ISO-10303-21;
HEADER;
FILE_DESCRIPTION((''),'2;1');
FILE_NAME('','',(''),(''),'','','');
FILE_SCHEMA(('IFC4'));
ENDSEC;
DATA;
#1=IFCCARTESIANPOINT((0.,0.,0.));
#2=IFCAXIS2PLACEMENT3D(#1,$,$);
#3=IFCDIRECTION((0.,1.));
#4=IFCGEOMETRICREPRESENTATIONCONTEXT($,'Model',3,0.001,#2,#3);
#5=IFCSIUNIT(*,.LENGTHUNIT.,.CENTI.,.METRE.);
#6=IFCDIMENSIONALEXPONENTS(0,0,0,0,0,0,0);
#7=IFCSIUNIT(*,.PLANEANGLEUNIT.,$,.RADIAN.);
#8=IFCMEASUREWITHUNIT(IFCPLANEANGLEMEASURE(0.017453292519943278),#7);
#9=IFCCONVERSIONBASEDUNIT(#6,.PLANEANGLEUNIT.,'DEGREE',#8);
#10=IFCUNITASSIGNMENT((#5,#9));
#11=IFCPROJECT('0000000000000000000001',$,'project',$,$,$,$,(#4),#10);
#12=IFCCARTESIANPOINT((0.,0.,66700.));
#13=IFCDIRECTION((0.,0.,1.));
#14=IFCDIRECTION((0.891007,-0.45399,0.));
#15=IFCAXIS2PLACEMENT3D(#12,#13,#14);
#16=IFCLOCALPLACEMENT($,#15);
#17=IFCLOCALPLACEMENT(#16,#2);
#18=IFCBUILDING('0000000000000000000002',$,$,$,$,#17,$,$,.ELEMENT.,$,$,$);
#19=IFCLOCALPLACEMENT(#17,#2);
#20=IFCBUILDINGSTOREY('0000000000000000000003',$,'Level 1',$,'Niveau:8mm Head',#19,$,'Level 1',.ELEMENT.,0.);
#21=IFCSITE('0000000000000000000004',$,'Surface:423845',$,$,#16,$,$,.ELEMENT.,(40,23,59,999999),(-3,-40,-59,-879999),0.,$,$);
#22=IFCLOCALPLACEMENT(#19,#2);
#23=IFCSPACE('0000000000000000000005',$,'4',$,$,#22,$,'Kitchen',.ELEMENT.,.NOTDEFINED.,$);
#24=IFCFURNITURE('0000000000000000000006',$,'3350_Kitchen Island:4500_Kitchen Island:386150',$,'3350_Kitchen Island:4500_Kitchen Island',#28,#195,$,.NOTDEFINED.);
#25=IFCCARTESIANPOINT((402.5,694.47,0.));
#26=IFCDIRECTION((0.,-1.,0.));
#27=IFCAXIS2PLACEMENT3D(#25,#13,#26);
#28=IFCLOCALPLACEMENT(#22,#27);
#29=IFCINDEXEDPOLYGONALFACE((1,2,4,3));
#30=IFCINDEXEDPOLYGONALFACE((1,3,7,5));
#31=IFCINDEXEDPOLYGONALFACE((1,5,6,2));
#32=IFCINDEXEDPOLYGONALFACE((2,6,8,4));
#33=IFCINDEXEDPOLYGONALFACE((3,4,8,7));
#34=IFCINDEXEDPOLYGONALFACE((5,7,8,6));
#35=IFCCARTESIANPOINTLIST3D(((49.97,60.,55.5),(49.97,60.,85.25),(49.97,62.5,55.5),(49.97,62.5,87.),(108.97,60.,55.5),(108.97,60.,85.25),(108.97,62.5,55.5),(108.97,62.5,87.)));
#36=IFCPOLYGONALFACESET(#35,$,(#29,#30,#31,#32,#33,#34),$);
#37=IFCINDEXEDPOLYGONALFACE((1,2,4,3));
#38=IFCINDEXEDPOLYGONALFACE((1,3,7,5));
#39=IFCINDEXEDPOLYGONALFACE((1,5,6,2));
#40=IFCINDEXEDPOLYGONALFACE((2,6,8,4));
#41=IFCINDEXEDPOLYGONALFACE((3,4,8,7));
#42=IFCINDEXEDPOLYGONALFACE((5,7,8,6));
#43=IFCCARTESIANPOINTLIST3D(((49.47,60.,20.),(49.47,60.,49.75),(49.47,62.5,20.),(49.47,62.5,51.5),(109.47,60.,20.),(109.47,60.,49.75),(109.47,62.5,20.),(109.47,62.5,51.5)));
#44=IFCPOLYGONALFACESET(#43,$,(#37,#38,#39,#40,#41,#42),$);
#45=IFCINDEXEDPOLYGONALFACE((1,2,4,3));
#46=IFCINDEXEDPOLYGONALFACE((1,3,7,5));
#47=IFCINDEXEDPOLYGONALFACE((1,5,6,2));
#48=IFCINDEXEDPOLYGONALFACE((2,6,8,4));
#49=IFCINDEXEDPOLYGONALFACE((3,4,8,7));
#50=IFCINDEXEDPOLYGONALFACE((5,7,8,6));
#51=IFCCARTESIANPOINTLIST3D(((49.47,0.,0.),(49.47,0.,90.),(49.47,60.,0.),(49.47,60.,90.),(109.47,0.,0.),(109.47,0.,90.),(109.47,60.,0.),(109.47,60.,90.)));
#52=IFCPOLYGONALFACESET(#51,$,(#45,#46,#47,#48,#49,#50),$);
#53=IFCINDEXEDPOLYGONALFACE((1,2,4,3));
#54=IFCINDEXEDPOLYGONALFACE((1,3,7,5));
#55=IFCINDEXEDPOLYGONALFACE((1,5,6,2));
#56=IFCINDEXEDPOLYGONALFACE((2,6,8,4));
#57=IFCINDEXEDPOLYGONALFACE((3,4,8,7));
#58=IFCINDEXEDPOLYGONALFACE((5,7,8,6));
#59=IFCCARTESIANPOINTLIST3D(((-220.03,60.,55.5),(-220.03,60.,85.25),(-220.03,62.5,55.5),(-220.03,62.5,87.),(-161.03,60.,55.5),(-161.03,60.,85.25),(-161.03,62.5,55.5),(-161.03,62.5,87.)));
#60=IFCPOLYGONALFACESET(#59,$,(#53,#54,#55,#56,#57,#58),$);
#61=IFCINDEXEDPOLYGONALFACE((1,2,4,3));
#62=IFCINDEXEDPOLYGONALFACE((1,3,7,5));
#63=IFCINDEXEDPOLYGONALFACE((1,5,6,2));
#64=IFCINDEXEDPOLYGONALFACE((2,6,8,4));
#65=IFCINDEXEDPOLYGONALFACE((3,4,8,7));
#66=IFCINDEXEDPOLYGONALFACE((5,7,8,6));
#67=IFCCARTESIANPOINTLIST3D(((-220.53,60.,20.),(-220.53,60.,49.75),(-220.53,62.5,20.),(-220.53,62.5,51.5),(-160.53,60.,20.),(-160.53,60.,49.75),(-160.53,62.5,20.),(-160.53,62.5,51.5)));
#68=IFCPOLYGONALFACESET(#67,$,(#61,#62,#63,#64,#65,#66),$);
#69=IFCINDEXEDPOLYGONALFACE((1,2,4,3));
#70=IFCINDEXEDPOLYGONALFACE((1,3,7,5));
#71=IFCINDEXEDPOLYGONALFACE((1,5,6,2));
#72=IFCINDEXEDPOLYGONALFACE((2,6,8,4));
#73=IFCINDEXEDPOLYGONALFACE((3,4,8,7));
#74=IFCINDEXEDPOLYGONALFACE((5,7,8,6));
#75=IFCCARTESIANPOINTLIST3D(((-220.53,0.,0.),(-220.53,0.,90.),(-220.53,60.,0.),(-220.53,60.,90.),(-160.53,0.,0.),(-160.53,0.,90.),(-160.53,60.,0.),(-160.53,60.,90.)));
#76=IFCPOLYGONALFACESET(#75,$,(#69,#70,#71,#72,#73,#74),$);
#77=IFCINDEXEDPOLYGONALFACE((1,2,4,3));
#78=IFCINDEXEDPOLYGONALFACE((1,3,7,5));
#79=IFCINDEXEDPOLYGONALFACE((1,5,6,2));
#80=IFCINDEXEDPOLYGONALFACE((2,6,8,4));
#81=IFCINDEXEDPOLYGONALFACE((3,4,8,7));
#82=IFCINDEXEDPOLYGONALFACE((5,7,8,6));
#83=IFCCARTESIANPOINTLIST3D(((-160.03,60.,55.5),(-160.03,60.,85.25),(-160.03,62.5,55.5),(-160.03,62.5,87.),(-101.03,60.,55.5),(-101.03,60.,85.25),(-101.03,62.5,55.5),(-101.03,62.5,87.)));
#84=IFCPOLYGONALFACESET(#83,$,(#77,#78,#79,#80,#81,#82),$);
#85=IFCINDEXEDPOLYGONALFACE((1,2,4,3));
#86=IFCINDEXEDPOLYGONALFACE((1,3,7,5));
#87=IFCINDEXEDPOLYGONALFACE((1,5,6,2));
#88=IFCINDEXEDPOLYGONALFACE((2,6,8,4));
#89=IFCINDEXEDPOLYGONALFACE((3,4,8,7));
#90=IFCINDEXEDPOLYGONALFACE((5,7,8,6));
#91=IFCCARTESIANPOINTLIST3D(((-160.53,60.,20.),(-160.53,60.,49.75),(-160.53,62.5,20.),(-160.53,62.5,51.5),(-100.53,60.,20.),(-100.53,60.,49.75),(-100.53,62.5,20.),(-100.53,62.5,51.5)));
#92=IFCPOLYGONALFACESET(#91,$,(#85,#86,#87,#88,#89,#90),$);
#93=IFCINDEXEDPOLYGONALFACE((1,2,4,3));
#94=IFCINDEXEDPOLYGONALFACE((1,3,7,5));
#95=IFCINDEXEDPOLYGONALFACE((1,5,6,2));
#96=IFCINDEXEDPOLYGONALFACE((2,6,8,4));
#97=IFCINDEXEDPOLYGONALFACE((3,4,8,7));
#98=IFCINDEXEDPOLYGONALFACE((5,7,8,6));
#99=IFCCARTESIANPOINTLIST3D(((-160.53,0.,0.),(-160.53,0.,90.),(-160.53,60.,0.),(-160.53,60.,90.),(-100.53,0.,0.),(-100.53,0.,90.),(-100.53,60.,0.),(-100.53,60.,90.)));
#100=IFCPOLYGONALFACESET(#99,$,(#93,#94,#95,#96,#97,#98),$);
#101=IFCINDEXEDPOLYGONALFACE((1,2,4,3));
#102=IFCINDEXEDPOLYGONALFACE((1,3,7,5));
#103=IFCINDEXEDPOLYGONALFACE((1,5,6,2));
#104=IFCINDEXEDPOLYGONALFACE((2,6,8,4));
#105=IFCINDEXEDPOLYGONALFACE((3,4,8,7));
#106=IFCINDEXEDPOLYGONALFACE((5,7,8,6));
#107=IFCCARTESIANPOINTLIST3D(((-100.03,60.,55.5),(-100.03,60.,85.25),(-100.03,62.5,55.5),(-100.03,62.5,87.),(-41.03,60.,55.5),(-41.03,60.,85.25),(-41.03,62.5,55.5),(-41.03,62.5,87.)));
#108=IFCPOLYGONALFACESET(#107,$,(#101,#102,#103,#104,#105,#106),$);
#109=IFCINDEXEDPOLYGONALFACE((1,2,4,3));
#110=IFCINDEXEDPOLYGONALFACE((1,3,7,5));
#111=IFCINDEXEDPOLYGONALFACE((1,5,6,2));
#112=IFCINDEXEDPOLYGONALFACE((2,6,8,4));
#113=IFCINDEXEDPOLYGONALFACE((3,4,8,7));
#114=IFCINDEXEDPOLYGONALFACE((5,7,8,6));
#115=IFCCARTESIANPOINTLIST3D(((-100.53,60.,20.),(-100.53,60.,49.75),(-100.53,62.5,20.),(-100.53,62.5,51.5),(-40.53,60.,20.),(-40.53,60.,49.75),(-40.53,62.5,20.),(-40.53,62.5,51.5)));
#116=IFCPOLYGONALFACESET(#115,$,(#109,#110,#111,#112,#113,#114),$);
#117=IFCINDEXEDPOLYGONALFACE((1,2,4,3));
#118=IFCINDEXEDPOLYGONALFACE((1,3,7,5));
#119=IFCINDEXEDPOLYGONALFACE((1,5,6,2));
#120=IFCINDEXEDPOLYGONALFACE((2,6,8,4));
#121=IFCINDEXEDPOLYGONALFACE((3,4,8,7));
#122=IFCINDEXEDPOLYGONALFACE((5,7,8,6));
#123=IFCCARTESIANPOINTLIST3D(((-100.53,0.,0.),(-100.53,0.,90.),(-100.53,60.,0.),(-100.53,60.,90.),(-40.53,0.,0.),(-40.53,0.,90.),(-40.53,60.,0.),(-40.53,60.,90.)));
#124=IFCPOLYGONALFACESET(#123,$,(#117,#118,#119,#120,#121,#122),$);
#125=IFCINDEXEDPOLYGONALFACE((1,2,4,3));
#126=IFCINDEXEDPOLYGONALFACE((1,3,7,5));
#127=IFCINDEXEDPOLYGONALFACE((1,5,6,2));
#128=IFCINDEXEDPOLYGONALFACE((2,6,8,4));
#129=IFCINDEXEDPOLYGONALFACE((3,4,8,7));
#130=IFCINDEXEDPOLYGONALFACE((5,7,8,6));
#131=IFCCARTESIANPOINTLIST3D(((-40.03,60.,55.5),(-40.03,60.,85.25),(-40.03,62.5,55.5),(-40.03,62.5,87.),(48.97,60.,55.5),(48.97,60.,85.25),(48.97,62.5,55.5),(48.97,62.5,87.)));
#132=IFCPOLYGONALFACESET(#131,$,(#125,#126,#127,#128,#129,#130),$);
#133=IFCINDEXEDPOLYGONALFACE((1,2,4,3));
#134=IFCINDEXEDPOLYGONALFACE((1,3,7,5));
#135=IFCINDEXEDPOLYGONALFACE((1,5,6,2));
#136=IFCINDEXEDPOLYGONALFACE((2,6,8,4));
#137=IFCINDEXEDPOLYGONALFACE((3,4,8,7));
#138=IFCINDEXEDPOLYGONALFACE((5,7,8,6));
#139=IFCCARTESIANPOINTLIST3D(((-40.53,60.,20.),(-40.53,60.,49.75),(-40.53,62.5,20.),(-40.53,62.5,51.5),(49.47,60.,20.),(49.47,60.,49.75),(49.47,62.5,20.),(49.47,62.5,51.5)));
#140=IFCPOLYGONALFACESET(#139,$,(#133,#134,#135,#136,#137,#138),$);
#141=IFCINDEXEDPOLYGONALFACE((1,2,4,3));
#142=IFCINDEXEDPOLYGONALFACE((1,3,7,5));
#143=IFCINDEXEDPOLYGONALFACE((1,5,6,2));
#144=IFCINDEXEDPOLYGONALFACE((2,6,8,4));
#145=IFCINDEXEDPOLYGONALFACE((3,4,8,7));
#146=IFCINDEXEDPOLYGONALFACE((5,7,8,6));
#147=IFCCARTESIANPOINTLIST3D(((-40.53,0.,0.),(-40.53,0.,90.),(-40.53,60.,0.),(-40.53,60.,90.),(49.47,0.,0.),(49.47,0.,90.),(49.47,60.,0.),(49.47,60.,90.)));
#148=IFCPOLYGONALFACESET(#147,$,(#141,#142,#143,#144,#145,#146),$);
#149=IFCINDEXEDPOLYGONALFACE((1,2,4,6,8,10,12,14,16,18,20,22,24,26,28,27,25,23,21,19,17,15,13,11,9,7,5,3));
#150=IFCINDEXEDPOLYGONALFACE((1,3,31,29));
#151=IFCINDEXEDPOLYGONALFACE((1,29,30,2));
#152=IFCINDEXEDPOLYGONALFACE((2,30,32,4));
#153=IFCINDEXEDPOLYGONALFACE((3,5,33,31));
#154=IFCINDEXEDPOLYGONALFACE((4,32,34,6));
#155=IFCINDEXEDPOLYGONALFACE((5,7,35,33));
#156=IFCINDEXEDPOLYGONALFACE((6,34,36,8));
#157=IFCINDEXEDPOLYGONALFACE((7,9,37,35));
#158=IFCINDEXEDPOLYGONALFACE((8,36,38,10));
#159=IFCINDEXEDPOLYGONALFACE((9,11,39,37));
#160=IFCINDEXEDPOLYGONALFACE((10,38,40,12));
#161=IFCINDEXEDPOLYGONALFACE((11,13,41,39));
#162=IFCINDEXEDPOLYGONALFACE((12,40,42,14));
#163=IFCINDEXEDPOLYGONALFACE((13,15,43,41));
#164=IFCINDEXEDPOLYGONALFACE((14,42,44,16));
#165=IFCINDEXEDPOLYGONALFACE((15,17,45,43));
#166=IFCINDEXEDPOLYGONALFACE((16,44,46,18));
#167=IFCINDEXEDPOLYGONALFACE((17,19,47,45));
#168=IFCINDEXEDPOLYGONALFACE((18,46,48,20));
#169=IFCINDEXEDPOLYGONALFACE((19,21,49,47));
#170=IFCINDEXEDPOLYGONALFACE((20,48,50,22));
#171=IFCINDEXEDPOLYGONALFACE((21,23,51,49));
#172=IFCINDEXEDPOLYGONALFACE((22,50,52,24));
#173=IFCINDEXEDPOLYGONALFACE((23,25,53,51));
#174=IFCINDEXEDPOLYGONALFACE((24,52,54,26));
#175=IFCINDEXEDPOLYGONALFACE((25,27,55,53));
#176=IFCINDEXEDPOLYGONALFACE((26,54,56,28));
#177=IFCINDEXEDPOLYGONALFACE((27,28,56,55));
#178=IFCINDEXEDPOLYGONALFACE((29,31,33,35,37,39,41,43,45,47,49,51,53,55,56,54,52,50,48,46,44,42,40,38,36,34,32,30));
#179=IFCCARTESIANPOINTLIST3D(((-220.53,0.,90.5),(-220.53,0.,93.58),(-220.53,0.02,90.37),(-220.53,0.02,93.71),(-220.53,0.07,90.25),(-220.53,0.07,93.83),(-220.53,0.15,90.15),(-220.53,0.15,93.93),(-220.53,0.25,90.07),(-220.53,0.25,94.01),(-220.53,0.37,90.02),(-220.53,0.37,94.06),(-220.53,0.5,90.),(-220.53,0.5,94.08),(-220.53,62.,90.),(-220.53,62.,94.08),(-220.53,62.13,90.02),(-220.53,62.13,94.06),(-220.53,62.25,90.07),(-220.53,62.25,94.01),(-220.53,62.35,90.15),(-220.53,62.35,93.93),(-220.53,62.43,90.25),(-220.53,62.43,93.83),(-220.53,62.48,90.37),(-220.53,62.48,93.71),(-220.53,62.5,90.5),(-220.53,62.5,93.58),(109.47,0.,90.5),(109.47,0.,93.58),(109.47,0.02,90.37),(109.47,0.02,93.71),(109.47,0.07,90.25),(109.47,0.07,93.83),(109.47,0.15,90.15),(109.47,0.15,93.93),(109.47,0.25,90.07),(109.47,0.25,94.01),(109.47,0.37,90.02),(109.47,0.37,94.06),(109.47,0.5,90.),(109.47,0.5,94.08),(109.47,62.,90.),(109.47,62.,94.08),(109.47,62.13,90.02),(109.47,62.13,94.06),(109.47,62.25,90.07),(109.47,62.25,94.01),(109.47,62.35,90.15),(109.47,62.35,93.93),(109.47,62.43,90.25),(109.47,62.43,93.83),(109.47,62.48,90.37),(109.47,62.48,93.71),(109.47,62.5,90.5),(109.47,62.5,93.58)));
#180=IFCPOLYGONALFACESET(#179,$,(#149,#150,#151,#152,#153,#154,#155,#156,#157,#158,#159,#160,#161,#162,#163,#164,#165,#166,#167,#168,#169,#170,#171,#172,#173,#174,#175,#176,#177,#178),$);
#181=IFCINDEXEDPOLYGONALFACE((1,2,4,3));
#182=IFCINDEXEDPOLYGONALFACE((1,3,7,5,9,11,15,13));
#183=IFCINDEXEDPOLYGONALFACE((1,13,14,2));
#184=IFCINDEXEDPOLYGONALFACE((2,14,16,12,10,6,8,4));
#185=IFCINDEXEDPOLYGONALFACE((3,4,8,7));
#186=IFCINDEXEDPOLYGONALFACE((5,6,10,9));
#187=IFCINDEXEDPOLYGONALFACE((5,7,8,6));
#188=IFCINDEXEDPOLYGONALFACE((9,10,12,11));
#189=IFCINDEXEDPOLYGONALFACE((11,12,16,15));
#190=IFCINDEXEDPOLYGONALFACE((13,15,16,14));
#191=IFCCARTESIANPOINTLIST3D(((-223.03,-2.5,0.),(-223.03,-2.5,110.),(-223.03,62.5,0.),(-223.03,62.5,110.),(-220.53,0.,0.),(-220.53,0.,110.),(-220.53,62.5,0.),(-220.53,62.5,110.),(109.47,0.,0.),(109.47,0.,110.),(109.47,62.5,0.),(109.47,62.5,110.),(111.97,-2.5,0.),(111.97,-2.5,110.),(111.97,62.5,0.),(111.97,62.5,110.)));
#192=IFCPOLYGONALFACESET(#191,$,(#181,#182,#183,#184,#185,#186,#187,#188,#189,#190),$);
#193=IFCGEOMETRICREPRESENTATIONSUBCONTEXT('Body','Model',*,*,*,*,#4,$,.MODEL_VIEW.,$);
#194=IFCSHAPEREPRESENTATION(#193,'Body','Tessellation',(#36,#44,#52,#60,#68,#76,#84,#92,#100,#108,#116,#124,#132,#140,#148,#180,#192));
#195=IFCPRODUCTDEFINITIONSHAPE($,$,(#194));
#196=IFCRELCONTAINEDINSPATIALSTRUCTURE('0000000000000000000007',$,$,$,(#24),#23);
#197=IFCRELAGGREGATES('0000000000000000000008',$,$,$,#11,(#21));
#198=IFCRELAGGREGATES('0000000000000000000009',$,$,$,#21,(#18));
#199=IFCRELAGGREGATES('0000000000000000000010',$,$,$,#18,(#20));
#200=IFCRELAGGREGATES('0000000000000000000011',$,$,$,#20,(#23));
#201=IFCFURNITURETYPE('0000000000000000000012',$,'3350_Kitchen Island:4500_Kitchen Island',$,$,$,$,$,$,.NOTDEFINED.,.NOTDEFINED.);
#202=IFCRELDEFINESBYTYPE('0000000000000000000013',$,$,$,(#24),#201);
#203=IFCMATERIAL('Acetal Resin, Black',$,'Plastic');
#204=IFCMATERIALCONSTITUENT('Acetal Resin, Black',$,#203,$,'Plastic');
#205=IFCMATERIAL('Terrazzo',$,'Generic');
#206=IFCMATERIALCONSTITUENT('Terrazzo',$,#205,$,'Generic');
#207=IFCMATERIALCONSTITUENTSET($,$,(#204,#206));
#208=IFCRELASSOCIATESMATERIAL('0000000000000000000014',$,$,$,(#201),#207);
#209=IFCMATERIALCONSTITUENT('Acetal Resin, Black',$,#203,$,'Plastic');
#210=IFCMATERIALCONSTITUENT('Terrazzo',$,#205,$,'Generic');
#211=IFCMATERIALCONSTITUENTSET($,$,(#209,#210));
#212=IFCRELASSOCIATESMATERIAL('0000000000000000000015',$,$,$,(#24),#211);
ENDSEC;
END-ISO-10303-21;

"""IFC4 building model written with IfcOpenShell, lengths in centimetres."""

from ifc_helpers import new_model, entity, si_unit, converted_unit, direction, frame, frame_2d, origin, place, context, subcontext, project, spatial, polyline, circle_curve, parameter, trimmed, segment, composite_curve, rectangle, outline, extrude, source, transform, mapped, material, constituent, constituent_set, type_object, type_shapes, element, save


model = new_model("IFC4")

# Units and contexts
model_context = context("Model", 3, precision=0.001, world=origin(), true_north=direction((0.0, 1.0)))
body_context = subcontext(model_context, "Body", "Model", "MODEL_VIEW")
ifc_project = project(units=[si_unit("LENGTHUNIT", "METRE", prefix="CENTI"), converted_unit("PLANEANGLEUNIT", "DEGREE", entity("IfcPlaneAngleMeasure", 0.017453292519943278), si_unit("PLANEANGLEUNIT", "RADIAN"), dimensions=[0, 0, 0, 0, 0, 0, 0])], contexts=[model_context])

# Site, building, storey
site_placement = place(None, frame((0.0, 0.0, 66700.0), z_axis=(0.0, 0.0, 1.0), x_axis=(0.891007, -0.45399, 0.0)))
site = spatial("IfcSite", under=ifc_project, at=site_placement, Name="Surface:423845", CompositionType="ELEMENT", RefLatitude=(40, 23, 59, 999999), RefLongitude=(-3, -40, -59, -879999), RefElevation=0.0)
building_placement = place(site_placement, origin())
building = spatial("IfcBuilding", under=site, at=building_placement, CompositionType="ELEMENT")
storey_placement = place(building_placement, origin())
storey = spatial("IfcBuildingStorey", under=building, at=storey_placement, Name="Level 1", ObjectType="Niveau:8mm Head", LongName="Level 1", CompositionType="ELEMENT", Elevation=0.0)

# Shared definitions
space_placement = place(storey_placement, origin())
space = spatial("IfcSpace", under=storey, at=space_placement, Name="4", LongName="Kitchen", CompositionType="ELEMENT", PredefinedType="NOTDEFINED")

# Furniture
ifc_material_1 = material(Name="Acetal Resin, Black", Category="Plastic")
ifc_material_2 = material(Name="Terrazzo", Category="Generic")
ifc_constituent_1 = constituent(ifc_material_1, Name="Acetal Resin, Black", Category="Plastic")
ifc_constituent_2 = constituent(ifc_material_2, Name="Terrazzo", Category="Generic")
ifc_constituent_set_1 = constituent_set(constituents=[ifc_constituent_1, ifc_constituent_2])
ifc_constituent_3 = constituent(ifc_material_1, Name="Acetal Resin, Black", Category="Plastic")
ifc_constituent_4 = constituent(ifc_material_2, Name="Terrazzo", Category="Generic")
ifc_constituent_set_2 = constituent_set(constituents=[ifc_constituent_3, ifc_constituent_4])
furniture_type_1 = type_object("IfcFurnitureType", Name="3350_Kitchen Island:4500_Kitchen Island", AssemblyPlace="NOTDEFINED", PredefinedType="NOTDEFINED", material=ifc_constituent_set_2)
shared_shape_1 = source(origin(), body_context, "Body", "SweptSolid", [
    extrude(outline(polyline([(-15.31, -1.25), (16.19, -1.25), (14.44, 1.25), (-15.31, 1.25), (-15.31, -1.25)])), frame((49.97, 61.25, 70.81), z_axis=(1.0, 0.0, 0.0), x_axis=(0.0, 0.0, 1.0)), (0.0, 0.0, 1.0), 59.0),
    extrude(outline(polyline([(-15.31, -1.25), (16.19, -1.25), (14.44, 1.25), (-15.31, 1.25), (-15.31, -1.25)])), frame((49.47, 61.25, 35.31), z_axis=(1.0, 0.0, 0.0), x_axis=(0.0, 0.0, 1.0)), (0.0, 0.0, 1.0), 60.0),
    extrude(rectangle(XDim=60.0, YDim=60.0, at=frame_2d((0.0, 0.0), x_axis=(1.0, 0.0))), frame((79.47, 30.0, 0.0), z_axis=(0.0, 0.0, 1.0), x_axis=(0.0, 1.0, 0.0)), (0.0, 0.0, 1.0), 90.0),
    extrude(outline(polyline([(-15.31, -1.25), (16.19, -1.25), (14.44, 1.25), (-15.31, 1.25), (-15.31, -1.25)])), frame((-220.03, 61.25, 70.81), z_axis=(1.0, 0.0, 0.0), x_axis=(0.0, 0.0, 1.0)), (0.0, 0.0, 1.0), 59.0),
    extrude(outline(polyline([(-15.31, -1.25), (16.19, -1.25), (14.44, 1.25), (-15.31, 1.25), (-15.31, -1.25)])), frame((-220.53, 61.25, 35.31), z_axis=(1.0, 0.0, 0.0), x_axis=(0.0, 0.0, 1.0)), (0.0, 0.0, 1.0), 60.0),
    extrude(rectangle(XDim=60.0, YDim=60.0, at=frame_2d((0.0, 0.0), x_axis=(1.0, 0.0))), frame((-190.53, 30.0, 0.0), z_axis=(0.0, 0.0, 1.0), x_axis=(0.0, 1.0, 0.0)), (0.0, 0.0, 1.0), 90.0),
    extrude(outline(polyline([(-15.31, -1.25), (16.19, -1.25), (14.44, 1.25), (-15.31, 1.25), (-15.31, -1.25)])), frame((-160.03, 61.25, 70.81), z_axis=(1.0, 0.0, 0.0), x_axis=(0.0, 0.0, 1.0)), (0.0, 0.0, 1.0), 59.0),
    extrude(outline(polyline([(-15.31, -1.25), (16.19, -1.25), (14.44, 1.25), (-15.31, 1.25), (-15.31, -1.25)])), frame((-160.53, 61.25, 35.31), z_axis=(1.0, 0.0, 0.0), x_axis=(0.0, 0.0, 1.0)), (0.0, 0.0, 1.0), 60.0),
    extrude(rectangle(XDim=60.0, YDim=60.0, at=frame_2d((0.0, 0.0), x_axis=(1.0, 0.0))), frame((-130.53, 30.0, 0.0), z_axis=(0.0, 0.0, 1.0), x_axis=(0.0, 1.0, 0.0)), (0.0, 0.0, 1.0), 90.0),
    extrude(outline(polyline([(-15.31, -1.25), (16.19, -1.25), (14.44, 1.25), (-15.31, 1.25), (-15.31, -1.25)])), frame((-100.03, 61.25, 70.81), z_axis=(1.0, 0.0, 0.0), x_axis=(0.0, 0.0, 1.0)), (0.0, 0.0, 1.0), 59.0),
    extrude(outline(polyline([(-15.31, -1.25), (16.19, -1.25), (14.44, 1.25), (-15.31, 1.25), (-15.31, -1.25)])), frame((-100.53, 61.25, 35.31), z_axis=(1.0, 0.0, 0.0), x_axis=(0.0, 0.0, 1.0)), (0.0, 0.0, 1.0), 60.0),
    extrude(rectangle(XDim=60.0, YDim=60.0, at=frame_2d((0.0, 0.0), x_axis=(1.0, 0.0))), frame((-70.53, 30.0, 0.0), z_axis=(0.0, 0.0, 1.0), x_axis=(0.0, 1.0, 0.0)), (0.0, 0.0, 1.0), 90.0),
    extrude(outline(polyline([(-15.31, -1.25), (16.19, -1.25), (14.44, 1.25), (-15.31, 1.25), (-15.31, -1.25)])), frame((-40.03, 61.25, 70.81), z_axis=(1.0, 0.0, 0.0), x_axis=(0.0, 0.0, 1.0)), (0.0, 0.0, 1.0), 89.0),
    extrude(outline(polyline([(-15.31, -1.25), (16.19, -1.25), (14.44, 1.25), (-15.31, 1.25), (-15.31, -1.25)])), frame((-40.53, 61.25, 35.31), z_axis=(1.0, 0.0, 0.0), x_axis=(0.0, 0.0, 1.0)), (0.0, 0.0, 1.0), 90.0),
    extrude(rectangle(XDim=60.0, YDim=90.0, at=frame_2d((0.0, 0.0), x_axis=(1.0, 0.0))), frame((4.47, 30.0, 0.0), z_axis=(0.0, 0.0, 1.0), x_axis=(0.0, 1.0, 0.0)), (0.0, 0.0, 1.0), 90.0),
    extrude(outline(composite_curve([segment(trimmed(circle_curve(frame_2d((-30.75, 1.54), x_axis=(1.0, 0.0)), 0.5), [parameter(90.0)], [parameter(180.0)], True, "PARAMETER"), True, "CONTINUOUS"), segment(polyline([(-31.25, 1.54), (-31.25, -1.54)]), True, "CONTINUOUS"), segment(trimmed(circle_curve(frame_2d((-30.75, -1.54), x_axis=(1.0, 0.0)), 0.5), [parameter(180.0)], [parameter(270.0)], True, "PARAMETER"), True, "CONTINUOUS"), segment(polyline([(-30.75, -2.04), (30.75, -2.04)]), True, "CONTINUOUS"), segment(trimmed(circle_curve(frame_2d((30.75, -1.54), x_axis=(1.0, 0.0)), 0.5), [parameter(270.0)], [parameter(360.0)], True, "PARAMETER"), True, "CONTINUOUS"), segment(polyline([(31.25, -1.54), (31.25, 1.54)]), True, "CONTINUOUS"), segment(trimmed(circle_curve(frame_2d((30.75, 1.54), x_axis=(1.0, 0.0)), 0.5), [parameter(0.0)], [parameter(90.0)], True, "PARAMETER"), True, "CONTINUOUS"), segment(polyline([(30.75, 2.04), (-30.75, 2.04)]), True, "CONTINUOUS")], self_intersect=False)), frame((-220.53, 31.25, 92.04), z_axis=(1.0, 0.0, 0.0), x_axis=(0.0, -1.0, 0.0)), (0.0, 0.0, 1.0), 330.0),
    extrude(outline(polyline([(-30.63, 165.0), (31.88, 165.0), (31.88, 167.5), (-33.13, 167.5), (-33.12, -167.5), (31.88, -167.5), (31.88, -165.0), (-30.62, -165.0), (-30.63, 165.0)])), frame((-55.53, 30.63, 0.0), z_axis=(0.0, 0.0, 1.0), x_axis=(0.0, 1.0, 0.0)), (0.0, 0.0, 1.0), 110.0),
])
type_shapes(furniture_type_1, [shared_shape_1])
furniture_1_placement = place(space_placement, frame((402.5, 694.47, 0.0), z_axis=(0.0, 0.0, 1.0), x_axis=(0.0, -1.0, 0.0)))
element("IfcFurniture", 1, at=furniture_1_placement, inside=space, type_object=furniture_type_1, material=ifc_constituent_set_1, Name="3350_Kitchen Island:4500_Kitchen Island:386150", ObjectType="3350_Kitchen Island:4500_Kitchen Island", PredefinedType="NOTDEFINED", context=body_context, shape_type="MappedRepresentation", body=[
    mapped(shared_shape_1, transform((0.0, 0.0, 0.0), scale=1.0)),
])

save(model, "model.ifc")
